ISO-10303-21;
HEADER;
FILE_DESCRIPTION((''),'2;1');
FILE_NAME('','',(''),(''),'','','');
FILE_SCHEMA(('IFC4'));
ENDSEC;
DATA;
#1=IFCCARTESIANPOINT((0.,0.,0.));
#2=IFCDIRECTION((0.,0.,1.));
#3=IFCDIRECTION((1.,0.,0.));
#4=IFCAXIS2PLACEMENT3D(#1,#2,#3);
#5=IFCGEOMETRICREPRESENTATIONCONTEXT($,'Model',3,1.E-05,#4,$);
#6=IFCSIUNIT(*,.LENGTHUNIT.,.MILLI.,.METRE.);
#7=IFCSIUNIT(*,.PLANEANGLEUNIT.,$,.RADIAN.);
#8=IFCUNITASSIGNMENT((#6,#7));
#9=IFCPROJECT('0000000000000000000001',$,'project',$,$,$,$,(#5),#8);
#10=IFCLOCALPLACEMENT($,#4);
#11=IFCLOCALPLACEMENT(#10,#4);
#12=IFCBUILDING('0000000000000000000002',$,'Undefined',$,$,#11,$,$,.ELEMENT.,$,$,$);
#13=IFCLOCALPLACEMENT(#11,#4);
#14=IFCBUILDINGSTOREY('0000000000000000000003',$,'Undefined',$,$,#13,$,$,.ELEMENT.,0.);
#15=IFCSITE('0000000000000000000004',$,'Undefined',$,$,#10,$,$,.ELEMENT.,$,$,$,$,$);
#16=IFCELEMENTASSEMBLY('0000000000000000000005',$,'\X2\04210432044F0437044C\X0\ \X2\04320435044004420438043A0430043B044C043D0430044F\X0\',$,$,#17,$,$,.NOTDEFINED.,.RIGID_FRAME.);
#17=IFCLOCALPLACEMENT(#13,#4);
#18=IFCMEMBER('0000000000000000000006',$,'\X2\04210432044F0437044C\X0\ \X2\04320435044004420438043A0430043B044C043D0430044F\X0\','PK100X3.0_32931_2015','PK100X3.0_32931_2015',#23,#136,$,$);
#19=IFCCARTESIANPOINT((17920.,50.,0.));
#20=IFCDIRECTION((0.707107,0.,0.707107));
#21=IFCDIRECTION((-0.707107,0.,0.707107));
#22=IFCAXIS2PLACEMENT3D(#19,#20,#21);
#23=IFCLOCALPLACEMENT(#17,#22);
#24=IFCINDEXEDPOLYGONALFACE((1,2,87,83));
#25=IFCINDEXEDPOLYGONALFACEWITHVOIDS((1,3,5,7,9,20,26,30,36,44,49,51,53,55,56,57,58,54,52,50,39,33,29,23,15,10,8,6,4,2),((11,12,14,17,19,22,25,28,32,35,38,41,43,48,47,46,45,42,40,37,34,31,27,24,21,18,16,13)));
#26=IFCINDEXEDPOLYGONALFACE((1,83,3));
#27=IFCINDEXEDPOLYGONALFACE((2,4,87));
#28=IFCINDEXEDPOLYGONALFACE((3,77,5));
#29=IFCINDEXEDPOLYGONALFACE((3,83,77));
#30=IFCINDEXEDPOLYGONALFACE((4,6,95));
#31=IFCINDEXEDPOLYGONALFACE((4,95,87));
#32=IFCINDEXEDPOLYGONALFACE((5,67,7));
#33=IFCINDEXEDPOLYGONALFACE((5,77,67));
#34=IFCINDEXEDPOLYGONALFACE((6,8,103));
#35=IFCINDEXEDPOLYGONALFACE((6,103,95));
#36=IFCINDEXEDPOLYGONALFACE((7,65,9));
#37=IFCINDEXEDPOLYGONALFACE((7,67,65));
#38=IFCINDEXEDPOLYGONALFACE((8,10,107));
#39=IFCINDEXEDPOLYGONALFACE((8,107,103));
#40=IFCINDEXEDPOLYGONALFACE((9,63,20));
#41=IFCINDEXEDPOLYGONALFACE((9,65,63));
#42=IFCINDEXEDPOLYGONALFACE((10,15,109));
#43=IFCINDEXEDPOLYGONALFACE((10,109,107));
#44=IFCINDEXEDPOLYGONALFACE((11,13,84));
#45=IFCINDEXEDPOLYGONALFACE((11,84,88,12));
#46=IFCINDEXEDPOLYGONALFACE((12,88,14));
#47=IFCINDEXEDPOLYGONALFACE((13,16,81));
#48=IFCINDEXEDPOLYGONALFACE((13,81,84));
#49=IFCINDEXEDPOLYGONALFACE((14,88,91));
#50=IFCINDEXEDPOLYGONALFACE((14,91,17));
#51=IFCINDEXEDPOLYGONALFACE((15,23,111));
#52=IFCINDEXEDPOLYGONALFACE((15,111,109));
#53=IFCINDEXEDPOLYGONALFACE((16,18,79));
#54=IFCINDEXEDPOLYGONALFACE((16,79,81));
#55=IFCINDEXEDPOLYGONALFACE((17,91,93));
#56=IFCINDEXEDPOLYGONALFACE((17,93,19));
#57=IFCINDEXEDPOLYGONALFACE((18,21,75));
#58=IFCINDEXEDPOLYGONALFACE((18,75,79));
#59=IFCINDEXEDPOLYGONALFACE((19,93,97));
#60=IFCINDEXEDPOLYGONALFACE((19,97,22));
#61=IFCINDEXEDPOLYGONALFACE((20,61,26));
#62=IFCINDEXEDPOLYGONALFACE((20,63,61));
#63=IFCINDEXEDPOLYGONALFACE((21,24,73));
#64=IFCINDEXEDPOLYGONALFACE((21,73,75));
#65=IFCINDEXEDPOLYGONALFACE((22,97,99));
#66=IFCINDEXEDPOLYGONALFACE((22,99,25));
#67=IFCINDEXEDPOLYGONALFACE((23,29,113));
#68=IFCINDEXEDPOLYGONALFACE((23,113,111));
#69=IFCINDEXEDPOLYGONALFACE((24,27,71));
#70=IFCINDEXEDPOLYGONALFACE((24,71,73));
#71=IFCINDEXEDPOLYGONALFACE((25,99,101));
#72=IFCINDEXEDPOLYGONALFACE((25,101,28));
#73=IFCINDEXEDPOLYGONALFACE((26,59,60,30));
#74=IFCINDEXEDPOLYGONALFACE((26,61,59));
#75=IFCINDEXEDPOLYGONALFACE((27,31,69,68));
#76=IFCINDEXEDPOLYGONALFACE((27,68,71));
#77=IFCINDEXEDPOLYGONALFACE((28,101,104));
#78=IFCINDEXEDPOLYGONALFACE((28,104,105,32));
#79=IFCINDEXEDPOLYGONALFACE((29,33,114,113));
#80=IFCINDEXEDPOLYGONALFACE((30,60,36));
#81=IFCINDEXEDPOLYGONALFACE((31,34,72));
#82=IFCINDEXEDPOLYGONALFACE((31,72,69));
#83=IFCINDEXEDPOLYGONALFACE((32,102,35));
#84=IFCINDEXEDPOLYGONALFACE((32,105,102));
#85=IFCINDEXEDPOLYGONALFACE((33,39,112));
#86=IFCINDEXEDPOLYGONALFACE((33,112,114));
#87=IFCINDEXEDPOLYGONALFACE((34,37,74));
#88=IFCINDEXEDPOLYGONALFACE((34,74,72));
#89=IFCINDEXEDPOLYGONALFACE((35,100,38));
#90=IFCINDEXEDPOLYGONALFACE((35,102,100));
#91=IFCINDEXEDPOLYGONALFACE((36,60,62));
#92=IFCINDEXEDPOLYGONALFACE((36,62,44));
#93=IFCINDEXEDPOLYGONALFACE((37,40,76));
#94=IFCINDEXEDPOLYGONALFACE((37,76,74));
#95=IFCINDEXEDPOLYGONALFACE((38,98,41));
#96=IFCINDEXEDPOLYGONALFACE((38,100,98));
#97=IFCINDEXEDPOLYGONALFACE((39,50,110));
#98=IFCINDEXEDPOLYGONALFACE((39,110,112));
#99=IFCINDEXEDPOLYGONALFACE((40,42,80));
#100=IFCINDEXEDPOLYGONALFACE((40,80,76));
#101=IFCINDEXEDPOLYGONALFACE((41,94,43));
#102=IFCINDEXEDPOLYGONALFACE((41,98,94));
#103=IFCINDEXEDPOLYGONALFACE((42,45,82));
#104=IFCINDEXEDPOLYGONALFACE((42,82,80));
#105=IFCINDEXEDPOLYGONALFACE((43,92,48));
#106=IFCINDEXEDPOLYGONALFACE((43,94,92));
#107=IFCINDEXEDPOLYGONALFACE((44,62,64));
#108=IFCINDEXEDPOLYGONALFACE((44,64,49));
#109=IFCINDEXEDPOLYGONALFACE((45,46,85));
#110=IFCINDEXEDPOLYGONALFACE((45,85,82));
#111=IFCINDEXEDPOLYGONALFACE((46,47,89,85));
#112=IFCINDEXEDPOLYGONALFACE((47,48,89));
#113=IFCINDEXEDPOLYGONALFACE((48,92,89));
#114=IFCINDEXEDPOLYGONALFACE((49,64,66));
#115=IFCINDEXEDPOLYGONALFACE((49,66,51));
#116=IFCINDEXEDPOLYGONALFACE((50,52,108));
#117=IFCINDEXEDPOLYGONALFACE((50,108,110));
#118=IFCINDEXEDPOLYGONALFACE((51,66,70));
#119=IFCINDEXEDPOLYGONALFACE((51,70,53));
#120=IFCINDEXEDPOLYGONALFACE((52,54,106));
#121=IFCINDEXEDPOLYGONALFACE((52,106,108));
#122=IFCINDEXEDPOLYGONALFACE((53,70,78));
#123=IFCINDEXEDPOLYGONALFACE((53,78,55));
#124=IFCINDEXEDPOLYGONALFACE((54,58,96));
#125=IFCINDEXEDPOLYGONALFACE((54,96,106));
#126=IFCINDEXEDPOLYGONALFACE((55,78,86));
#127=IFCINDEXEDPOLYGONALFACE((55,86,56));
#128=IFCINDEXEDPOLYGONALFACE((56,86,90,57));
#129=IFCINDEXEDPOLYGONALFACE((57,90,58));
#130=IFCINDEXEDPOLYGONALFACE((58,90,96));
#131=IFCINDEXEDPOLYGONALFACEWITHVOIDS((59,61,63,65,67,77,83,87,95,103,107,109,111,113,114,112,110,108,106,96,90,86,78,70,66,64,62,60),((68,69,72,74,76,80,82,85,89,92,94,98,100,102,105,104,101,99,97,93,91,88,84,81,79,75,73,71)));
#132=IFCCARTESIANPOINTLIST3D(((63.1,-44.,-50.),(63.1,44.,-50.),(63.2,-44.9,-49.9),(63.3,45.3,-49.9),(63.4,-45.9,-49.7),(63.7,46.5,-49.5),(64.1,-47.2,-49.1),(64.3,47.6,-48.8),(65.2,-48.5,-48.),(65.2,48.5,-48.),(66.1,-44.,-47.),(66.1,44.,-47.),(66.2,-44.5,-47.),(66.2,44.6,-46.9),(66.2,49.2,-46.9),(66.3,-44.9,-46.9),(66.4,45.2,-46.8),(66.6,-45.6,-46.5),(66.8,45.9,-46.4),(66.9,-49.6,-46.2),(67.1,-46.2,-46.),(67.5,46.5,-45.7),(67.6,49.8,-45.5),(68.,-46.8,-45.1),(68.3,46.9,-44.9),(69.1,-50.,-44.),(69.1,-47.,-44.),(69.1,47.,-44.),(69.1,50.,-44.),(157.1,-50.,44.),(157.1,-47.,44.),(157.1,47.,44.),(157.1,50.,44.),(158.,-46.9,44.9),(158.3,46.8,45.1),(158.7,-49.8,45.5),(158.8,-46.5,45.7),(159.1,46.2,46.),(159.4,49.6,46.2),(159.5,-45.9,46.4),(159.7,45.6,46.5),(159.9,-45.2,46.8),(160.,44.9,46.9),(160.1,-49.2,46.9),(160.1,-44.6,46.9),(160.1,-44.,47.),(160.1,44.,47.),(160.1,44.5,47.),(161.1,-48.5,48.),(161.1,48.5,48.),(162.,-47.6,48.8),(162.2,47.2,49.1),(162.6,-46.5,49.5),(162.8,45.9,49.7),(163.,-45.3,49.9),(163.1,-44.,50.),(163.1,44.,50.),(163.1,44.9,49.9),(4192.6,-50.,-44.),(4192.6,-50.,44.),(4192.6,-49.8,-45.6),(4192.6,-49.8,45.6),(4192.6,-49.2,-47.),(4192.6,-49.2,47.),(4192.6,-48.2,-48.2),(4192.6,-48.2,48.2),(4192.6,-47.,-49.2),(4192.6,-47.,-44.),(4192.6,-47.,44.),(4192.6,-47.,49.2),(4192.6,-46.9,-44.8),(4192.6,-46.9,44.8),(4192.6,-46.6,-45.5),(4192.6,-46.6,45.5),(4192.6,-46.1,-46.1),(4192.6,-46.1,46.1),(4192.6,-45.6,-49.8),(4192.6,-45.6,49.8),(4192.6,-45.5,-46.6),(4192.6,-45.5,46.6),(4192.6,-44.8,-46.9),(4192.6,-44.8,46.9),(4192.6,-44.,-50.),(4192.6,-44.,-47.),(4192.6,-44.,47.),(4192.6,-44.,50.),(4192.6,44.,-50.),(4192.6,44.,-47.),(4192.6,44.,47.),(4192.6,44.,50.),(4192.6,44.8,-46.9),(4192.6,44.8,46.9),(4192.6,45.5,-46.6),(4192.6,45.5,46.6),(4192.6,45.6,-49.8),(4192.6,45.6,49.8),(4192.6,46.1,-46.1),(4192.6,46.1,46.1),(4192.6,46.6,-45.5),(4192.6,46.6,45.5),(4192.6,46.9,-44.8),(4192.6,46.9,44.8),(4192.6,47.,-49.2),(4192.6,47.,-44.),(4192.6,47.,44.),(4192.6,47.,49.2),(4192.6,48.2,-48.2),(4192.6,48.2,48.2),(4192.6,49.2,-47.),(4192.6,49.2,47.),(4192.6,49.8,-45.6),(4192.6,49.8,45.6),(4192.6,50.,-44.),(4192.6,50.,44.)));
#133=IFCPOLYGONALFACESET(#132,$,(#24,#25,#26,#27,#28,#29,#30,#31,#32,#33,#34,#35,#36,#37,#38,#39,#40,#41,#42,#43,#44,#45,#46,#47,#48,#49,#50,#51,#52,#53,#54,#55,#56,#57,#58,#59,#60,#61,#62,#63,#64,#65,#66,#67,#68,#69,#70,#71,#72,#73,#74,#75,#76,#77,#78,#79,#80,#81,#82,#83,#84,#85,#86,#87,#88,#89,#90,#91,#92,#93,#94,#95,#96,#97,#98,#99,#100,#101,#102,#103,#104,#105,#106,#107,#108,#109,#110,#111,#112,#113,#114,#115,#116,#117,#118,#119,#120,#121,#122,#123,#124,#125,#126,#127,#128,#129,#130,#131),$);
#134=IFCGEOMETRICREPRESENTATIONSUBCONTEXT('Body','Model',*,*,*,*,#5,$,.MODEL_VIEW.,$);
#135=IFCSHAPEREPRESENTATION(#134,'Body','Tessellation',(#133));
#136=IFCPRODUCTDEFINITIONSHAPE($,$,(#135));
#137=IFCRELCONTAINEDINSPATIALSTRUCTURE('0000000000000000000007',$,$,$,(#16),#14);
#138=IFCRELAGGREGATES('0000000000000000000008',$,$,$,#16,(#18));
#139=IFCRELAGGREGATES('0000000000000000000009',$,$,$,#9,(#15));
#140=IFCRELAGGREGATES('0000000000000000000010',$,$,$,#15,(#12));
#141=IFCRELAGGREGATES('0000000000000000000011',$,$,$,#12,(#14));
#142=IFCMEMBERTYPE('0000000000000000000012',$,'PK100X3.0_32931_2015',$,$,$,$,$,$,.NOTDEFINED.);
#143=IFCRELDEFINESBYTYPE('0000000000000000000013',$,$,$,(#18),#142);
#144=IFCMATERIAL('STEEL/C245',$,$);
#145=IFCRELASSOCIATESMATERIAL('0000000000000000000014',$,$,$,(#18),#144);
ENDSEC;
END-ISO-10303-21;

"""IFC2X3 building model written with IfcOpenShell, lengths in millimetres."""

from ifc_helpers import new_model, si_unit, frame, origin_with_axes, origin_2d_with_axis, place, context, subcontext, project, spatial, hollow_rectangle, extrude, clip, halfspace, material, type_object, element, aggregate, save


model = new_model("IFC2X3")

# Units and contexts
model_context = context("Model", 3, precision=1e-05, world=origin_with_axes())
body_context = subcontext(model_context, "Body", "Model", "MODEL_VIEW")
ifc_project = project(units=[si_unit("LENGTHUNIT", "METRE", prefix="MILLI"), si_unit("PLANEANGLEUNIT", "RADIAN")], contexts=[model_context])

# Site, building, storey
site_placement = place(None, origin_with_axes())
site = spatial("IfcSite", under=ifc_project, at=site_placement, Name="Undefined", CompositionType="ELEMENT")
building_placement = place(site_placement, origin_with_axes())
building = spatial("IfcBuilding", under=site, at=building_placement, Name="Undefined", CompositionType="ELEMENT")
storey_placement = place(building_placement, origin_with_axes())
storey = spatial("IfcBuildingStorey", under=building, at=storey_placement, Name="Undefined", CompositionType="ELEMENT", Elevation=0.0)

# Shared definitions
ifc_material = material(Name="STEEL/C245")

# Element assembly, member
assembly_1_placement = place(storey_placement, origin_with_axes())
assembly_1 = element("IfcElementAssembly", 1, at=assembly_1_placement, inside=storey, Name="Связь вертикальная", AssemblyPlace="NOTDEFINED", PredefinedType="RIGID_FRAME")
member_type_1 = type_object("IfcMemberType", Name="PK100X3.0_32931_2015", PredefinedType="NOTDEFINED")
member_1_placement = place(assembly_1_placement, frame((17920.0, 50.0, 0.0), z_axis=(0.707107, 0.0, 0.707107), x_axis=(-0.707107, 0.0, 0.707107)))
member_1 = element("IfcMember", 2, at=member_1_placement, type_object=member_type_1, material=ifc_material, Name="Связь вертикальная", Description="PK100X3.0_32931_2015", ObjectType="PK100X3.0_32931_2015", context=body_context, shape_type="Clipping", body=[
    clip(clip(extrude(hollow_rectangle(XDim=100.0, YDim=100.0, WallThickness=3.0, InnerFilletRadius=3.0, OuterFilletRadius=6.0, at=origin_2d_with_axis()), frame((4293.6, 0.0, 0.0), z_axis=(-1.0, 0.0, 0.0), x_axis=(0.0, -1.0, 0.0)), (0.0, 0.0, 1.0), 4281.5), halfspace(frame((4192.6, 50.0, -95.9), z_axis=(-1.0, 0.0, 0.0), x_axis=(0.0, 1.0, 0.0)), True)), halfspace(frame((281.0, 50.0, 167.8), z_axis=(0.707107, 0.0, -0.707107), x_axis=(0.707107, 0.0, 0.707107)), True)),
])
aggregate(assembly_1, [member_1])

save(model, "model.ifc")
